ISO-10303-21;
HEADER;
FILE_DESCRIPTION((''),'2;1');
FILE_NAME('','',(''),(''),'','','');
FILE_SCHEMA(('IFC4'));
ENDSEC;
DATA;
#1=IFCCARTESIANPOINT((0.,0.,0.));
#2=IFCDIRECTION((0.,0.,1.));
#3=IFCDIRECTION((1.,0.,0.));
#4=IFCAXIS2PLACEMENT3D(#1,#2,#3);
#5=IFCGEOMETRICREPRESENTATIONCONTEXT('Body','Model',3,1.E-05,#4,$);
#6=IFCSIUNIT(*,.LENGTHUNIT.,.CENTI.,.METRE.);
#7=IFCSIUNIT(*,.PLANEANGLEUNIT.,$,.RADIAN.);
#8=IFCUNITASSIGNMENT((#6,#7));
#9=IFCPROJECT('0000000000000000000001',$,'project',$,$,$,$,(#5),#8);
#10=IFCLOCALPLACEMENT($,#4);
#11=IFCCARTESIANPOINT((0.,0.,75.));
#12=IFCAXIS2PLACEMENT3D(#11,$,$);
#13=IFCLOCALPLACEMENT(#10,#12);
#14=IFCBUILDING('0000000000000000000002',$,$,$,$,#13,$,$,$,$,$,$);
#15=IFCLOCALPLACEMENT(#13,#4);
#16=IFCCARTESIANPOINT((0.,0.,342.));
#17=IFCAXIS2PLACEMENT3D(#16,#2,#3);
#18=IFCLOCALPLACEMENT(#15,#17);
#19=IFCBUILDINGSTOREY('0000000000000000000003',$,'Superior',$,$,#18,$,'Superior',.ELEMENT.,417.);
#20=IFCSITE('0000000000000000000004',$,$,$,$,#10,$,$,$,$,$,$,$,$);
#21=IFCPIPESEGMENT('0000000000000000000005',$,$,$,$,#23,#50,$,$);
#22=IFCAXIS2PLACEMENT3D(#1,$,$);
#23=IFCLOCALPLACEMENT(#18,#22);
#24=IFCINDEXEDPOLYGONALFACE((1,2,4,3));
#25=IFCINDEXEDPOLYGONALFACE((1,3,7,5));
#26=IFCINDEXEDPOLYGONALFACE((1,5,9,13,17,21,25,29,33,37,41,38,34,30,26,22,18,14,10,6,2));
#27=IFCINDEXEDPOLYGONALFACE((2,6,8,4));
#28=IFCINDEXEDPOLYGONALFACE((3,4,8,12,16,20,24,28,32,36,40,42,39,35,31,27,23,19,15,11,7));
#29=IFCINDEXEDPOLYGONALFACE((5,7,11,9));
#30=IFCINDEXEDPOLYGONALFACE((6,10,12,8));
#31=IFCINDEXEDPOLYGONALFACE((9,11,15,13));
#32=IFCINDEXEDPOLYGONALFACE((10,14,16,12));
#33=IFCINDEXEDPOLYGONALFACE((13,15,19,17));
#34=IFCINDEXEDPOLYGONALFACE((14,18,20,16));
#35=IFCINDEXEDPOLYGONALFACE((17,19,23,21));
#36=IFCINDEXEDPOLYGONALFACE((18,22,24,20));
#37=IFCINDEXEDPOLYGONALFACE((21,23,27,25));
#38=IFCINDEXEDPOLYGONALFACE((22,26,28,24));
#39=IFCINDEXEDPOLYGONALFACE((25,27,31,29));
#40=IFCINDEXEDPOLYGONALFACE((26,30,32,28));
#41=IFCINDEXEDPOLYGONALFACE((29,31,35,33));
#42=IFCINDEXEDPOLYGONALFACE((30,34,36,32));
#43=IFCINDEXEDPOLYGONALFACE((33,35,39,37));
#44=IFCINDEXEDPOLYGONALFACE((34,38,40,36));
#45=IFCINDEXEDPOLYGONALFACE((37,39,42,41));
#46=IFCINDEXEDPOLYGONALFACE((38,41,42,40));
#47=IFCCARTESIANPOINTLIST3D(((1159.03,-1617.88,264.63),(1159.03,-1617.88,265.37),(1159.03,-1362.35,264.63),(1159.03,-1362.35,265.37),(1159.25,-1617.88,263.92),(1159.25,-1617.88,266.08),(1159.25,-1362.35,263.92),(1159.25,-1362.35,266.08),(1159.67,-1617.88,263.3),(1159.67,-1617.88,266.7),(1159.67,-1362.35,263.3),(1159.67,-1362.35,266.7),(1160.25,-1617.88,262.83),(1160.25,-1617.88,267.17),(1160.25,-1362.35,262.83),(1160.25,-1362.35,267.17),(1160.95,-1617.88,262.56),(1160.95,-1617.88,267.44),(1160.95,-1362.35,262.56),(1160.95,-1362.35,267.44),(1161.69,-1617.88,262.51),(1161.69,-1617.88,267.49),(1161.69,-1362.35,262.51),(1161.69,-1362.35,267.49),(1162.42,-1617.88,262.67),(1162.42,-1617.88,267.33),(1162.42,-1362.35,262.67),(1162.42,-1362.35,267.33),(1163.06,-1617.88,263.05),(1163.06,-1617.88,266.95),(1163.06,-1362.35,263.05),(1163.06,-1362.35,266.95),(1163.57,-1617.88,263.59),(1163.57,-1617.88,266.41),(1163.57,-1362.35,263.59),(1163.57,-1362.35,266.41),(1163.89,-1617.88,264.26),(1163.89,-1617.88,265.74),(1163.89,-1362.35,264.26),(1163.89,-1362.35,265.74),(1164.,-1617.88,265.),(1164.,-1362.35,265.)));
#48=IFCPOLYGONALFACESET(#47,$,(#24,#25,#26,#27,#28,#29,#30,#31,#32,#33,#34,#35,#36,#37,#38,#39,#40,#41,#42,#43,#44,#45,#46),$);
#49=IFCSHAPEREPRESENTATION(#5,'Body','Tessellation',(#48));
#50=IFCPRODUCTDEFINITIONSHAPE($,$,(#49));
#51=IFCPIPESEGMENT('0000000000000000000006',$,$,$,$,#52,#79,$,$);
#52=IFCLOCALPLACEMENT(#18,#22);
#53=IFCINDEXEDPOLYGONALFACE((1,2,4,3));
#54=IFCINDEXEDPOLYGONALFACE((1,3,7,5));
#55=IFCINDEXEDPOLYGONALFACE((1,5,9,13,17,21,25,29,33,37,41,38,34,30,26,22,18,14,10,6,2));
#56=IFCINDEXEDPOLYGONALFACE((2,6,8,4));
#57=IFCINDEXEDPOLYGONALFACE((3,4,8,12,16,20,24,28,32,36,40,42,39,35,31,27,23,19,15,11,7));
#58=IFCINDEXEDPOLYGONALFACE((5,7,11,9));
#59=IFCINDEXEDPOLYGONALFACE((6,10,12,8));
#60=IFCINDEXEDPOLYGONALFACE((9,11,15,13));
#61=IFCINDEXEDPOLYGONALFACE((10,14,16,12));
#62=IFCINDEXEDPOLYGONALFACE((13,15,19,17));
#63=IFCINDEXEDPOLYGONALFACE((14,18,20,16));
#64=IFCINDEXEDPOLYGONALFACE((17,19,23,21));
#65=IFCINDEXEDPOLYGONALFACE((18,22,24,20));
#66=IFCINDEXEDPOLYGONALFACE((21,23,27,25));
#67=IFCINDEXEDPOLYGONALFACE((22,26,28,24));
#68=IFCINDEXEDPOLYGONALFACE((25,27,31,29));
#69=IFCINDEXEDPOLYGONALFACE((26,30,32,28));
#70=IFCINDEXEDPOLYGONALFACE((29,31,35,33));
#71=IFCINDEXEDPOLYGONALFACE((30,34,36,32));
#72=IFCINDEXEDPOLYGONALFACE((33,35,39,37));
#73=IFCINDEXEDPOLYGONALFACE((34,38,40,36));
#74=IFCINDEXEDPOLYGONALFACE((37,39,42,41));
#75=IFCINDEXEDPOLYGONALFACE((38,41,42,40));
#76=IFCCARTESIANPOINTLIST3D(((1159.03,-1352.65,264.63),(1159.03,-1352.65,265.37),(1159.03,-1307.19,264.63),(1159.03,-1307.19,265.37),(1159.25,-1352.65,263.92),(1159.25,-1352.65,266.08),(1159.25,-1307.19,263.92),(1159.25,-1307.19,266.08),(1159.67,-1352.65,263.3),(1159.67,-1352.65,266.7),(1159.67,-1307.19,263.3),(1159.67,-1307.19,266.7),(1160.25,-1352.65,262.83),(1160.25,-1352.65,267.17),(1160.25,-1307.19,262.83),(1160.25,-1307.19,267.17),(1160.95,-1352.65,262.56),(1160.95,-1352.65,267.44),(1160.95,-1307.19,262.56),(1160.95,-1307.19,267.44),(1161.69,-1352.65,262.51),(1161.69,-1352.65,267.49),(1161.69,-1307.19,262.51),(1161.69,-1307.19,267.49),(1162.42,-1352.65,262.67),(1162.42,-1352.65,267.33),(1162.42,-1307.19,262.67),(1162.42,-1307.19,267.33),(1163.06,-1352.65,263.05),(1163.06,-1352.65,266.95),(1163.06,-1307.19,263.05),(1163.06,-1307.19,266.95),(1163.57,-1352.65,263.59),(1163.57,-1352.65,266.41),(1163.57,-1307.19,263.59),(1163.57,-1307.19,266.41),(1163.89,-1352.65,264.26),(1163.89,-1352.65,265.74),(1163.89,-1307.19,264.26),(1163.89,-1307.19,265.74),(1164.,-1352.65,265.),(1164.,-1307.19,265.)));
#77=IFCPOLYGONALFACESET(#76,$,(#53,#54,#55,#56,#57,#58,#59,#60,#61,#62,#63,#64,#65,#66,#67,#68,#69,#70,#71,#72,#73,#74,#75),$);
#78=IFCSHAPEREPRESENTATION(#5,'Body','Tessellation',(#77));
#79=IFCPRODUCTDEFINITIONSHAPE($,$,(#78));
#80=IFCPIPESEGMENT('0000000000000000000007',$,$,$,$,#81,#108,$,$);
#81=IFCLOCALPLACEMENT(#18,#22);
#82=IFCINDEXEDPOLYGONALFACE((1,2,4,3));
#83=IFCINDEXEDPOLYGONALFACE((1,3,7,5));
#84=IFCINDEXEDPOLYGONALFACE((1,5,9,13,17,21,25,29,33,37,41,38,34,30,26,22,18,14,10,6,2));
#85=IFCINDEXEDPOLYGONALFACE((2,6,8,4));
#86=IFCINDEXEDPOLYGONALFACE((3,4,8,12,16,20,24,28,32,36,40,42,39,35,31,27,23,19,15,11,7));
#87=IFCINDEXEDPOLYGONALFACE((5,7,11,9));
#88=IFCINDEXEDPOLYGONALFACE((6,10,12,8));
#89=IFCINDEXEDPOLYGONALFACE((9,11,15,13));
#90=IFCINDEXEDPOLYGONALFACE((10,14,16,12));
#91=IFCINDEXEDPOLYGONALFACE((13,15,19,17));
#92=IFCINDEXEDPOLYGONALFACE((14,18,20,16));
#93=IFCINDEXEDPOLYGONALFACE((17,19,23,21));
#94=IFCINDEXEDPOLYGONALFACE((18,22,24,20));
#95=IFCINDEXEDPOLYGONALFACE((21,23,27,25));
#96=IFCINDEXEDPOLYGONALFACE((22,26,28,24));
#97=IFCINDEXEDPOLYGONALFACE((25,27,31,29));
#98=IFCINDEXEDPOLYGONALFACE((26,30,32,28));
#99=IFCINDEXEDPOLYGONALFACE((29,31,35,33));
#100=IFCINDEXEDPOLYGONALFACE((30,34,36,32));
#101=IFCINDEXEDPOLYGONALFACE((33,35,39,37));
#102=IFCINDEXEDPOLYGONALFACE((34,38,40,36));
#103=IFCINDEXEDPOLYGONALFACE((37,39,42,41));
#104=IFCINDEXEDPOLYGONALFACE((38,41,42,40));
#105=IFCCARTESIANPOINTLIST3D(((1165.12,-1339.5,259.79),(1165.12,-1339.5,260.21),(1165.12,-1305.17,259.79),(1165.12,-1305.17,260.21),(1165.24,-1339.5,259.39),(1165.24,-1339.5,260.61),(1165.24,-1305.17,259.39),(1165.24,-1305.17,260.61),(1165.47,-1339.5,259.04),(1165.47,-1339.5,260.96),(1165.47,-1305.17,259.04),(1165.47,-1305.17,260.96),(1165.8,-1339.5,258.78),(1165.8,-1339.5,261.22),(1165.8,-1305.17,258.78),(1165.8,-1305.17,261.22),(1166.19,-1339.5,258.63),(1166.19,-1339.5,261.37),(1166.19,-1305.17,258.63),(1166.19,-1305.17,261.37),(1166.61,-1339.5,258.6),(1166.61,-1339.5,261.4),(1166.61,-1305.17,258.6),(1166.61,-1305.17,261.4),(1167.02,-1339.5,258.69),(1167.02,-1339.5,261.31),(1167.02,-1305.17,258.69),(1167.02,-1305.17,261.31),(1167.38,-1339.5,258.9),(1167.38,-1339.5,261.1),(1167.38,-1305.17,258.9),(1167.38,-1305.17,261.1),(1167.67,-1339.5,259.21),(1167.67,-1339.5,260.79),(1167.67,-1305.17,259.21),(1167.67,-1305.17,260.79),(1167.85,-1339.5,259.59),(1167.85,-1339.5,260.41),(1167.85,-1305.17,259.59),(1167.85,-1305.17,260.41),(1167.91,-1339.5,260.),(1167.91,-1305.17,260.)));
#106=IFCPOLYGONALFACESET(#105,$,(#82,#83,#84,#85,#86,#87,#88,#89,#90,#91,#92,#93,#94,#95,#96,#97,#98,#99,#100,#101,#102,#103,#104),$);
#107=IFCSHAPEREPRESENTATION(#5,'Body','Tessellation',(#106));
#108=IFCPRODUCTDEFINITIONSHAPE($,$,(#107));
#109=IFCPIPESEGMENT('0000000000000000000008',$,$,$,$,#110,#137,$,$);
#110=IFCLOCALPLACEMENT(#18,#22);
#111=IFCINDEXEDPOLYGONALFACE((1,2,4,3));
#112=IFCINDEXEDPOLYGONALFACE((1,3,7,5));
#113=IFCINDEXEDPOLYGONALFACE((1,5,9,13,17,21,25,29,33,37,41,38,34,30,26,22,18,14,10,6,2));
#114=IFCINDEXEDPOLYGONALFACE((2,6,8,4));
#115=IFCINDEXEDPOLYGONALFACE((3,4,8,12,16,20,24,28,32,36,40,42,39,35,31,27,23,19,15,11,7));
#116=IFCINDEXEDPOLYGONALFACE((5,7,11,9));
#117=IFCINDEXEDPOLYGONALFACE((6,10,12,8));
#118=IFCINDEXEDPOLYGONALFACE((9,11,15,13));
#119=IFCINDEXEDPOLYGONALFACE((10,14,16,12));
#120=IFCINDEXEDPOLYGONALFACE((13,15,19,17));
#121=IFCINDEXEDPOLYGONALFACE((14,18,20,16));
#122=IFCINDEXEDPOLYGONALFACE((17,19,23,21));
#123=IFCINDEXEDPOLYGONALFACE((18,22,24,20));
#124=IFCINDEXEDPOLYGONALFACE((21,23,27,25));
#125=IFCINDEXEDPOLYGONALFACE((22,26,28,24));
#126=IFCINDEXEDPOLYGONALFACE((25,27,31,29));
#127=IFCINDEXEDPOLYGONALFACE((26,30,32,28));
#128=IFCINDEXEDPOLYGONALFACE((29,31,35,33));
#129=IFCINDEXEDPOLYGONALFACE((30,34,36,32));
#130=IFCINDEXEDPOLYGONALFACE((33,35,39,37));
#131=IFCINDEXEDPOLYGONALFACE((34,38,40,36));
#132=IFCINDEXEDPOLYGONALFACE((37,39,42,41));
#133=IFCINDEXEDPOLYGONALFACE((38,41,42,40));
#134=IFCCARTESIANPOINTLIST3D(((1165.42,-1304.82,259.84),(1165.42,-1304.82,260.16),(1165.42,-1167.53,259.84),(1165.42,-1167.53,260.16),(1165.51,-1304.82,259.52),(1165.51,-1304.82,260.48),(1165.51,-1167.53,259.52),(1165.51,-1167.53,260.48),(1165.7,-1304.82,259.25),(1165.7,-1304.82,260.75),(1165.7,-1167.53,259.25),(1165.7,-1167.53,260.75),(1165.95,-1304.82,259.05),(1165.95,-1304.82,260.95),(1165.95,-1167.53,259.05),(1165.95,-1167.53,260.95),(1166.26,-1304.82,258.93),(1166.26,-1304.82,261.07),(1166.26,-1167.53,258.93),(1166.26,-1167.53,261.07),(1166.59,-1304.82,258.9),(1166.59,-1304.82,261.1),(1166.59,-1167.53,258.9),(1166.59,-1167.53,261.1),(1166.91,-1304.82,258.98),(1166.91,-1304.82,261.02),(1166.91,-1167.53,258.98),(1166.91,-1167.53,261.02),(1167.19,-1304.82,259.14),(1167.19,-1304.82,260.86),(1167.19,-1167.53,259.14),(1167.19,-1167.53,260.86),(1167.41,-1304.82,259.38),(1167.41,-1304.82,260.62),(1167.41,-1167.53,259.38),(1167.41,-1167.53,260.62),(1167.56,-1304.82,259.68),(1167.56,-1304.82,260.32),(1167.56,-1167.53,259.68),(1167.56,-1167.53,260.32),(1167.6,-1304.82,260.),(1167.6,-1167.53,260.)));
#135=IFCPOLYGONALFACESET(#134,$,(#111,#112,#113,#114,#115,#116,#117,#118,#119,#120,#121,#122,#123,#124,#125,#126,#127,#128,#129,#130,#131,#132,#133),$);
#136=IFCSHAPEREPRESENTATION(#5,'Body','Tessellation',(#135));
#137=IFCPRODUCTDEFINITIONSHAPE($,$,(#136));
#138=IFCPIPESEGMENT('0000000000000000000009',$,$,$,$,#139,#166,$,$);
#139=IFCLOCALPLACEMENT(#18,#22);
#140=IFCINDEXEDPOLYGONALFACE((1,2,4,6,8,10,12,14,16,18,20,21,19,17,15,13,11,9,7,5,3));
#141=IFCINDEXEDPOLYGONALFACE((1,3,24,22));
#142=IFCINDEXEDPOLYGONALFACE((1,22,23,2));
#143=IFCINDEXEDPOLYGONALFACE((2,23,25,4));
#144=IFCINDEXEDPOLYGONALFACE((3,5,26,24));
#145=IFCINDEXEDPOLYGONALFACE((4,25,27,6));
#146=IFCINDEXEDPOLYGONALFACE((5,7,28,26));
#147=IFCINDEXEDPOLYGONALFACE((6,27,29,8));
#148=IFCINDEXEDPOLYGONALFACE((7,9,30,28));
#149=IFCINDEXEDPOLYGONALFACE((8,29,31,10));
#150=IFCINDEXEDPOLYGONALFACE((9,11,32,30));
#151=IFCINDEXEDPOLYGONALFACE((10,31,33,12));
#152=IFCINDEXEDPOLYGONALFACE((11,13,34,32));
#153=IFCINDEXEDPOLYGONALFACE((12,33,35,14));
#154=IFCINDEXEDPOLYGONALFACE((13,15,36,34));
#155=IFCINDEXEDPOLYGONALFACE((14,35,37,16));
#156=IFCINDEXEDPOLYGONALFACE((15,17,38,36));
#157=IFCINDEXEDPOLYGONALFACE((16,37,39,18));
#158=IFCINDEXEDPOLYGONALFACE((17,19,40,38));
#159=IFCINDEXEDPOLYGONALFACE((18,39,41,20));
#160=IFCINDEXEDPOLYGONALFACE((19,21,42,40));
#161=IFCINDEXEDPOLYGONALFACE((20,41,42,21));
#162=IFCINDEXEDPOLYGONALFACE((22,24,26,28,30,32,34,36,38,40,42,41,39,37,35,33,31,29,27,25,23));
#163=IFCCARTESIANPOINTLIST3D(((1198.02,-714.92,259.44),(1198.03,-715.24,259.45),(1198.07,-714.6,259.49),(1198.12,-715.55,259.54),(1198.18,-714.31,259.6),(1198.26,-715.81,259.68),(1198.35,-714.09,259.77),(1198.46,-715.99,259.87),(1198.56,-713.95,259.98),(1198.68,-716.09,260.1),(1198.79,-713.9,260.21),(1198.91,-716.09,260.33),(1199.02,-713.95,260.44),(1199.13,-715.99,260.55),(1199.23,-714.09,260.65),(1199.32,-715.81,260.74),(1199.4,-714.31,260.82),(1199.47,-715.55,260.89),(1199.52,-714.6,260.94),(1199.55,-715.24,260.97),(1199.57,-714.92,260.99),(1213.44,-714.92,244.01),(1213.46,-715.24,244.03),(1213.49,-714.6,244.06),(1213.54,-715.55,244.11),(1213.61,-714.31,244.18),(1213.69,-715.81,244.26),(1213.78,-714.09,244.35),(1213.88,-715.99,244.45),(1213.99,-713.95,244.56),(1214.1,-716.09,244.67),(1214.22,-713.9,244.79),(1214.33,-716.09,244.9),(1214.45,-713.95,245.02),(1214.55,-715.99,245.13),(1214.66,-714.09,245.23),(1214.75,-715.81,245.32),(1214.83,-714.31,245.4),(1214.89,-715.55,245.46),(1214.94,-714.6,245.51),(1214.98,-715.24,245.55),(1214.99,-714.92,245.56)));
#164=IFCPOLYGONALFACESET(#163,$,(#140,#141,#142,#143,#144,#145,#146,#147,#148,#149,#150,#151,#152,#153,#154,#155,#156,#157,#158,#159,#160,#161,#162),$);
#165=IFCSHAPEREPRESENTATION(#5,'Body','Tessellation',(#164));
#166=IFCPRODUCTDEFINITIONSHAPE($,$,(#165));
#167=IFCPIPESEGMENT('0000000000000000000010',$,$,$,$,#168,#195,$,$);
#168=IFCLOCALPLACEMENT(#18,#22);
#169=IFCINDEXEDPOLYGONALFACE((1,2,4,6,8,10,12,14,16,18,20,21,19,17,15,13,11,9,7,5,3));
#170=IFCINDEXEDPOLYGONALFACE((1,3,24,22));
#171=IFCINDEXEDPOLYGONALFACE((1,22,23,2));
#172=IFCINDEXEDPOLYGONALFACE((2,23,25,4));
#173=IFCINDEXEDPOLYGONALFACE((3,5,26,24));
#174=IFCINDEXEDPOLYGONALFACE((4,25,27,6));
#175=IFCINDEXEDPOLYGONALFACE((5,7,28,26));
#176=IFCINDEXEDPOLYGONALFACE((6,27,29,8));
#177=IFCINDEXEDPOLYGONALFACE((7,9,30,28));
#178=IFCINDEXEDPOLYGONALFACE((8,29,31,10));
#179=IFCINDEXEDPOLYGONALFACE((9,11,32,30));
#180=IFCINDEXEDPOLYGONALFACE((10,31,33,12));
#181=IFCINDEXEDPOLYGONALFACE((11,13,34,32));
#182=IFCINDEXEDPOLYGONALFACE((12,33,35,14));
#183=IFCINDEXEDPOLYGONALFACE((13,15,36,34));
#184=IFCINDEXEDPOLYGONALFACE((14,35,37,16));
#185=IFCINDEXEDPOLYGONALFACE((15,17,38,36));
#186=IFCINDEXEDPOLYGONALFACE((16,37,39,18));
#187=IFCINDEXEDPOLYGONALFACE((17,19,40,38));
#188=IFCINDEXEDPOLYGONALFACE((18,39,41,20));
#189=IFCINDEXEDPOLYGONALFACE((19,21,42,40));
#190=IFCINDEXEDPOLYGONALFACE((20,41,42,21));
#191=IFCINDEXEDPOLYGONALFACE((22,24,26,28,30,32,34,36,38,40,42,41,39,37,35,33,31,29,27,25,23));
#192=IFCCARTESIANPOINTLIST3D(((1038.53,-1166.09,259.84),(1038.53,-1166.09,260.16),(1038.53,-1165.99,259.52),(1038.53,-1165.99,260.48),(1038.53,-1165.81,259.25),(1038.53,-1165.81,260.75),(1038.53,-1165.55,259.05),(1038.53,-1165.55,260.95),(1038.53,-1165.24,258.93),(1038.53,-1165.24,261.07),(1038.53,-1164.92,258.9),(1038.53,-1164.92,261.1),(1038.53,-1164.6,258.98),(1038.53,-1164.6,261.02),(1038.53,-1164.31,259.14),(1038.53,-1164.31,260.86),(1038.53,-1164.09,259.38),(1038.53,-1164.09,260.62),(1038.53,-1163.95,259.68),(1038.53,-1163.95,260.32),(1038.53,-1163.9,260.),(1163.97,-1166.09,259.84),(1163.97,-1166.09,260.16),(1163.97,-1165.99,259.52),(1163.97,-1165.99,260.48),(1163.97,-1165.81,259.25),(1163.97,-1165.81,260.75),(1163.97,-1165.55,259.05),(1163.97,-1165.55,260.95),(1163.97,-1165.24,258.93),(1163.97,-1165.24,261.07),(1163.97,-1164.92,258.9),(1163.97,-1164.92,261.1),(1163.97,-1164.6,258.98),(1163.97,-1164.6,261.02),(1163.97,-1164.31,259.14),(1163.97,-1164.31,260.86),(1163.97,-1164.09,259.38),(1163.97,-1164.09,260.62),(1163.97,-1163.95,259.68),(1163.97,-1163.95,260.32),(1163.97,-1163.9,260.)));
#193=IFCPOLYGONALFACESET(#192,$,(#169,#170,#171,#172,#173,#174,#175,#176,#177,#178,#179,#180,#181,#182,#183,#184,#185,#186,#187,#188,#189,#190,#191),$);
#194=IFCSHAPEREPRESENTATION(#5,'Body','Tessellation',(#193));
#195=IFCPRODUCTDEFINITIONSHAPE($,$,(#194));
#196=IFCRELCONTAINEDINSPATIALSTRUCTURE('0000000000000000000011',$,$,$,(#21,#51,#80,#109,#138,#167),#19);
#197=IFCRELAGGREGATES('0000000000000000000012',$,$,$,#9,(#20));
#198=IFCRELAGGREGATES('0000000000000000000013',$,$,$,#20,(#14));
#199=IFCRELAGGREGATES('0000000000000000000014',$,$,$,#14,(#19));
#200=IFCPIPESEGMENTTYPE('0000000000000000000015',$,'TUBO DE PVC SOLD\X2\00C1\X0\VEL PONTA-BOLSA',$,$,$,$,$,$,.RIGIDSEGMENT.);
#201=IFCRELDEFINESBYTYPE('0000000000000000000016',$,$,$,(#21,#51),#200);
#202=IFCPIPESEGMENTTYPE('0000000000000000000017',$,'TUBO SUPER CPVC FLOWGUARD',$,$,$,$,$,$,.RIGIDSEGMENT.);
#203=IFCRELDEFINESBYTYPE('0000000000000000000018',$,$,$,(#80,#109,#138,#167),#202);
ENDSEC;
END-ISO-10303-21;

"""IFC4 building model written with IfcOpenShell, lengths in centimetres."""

from ifc_helpers import new_model, si_unit, frame, origin_with_axes, origin_2d_with_axis, place, context, project, spatial, circle, extrude, type_object, element, save


model = new_model("IFC4")

# Units and contexts
model_context = context("Model", 3, precision=1e-05, world=origin_with_axes(), identifier="Body")
ifc_project = project(units=[si_unit("LENGTHUNIT", "METRE", prefix="CENTI"), si_unit("PLANEANGLEUNIT", "RADIAN")], contexts=[model_context])

# Site, building, storey
site_placement = place(None, origin_with_axes())
site = spatial("IfcSite", under=ifc_project, at=site_placement)
building_placement = place(site_placement, frame((0.0, 0.0, 75.0)))
building = spatial("IfcBuilding", under=site, at=building_placement)
placement = place(building_placement, origin_with_axes())
storey_placement = place(placement, frame((0.0, 0.0, 342.0), z_axis=(0.0, 0.0, 1.0), x_axis=(1.0, 0.0, 0.0)))
storey = spatial("IfcBuildingStorey", under=building, at=storey_placement, Name="Superior", LongName="Superior", CompositionType="ELEMENT", Elevation=417.0)

# Pipe segments
pipe_segment_type_1 = type_object("IfcPipeSegmentType", Name="TUBO DE PVC SOLDÁVEL PONTA-BOLSA", PredefinedType="RIGIDSEGMENT")
pipe_segment_1_placement = place(storey_placement, frame((1161.5, -1490.11, 267.5), z_axis=(0.0, 0.0, 1.0), x_axis=(1.0, 0.0, 0.0)))
element("IfcPipeSegment", 1, at=pipe_segment_1_placement, inside=storey, type_object=pipe_segment_type_1, context=model_context, shape_type="SolidModel", body=[
    extrude(circle(Radius=2.5, at=origin_2d_with_axis()), frame((0.0, 127.77, -2.5), z_axis=(0.0, -1.0, 0.0), x_axis=(1.0, 0.0, 0.0)), (0.0, 0.0, 1.0), 255.53),
])
pipe_segment_2_placement = place(storey_placement, frame((1161.5, -1329.92, 267.5), z_axis=(0.0, 0.0, 1.0), x_axis=(1.0, 0.0, 0.0)))
element("IfcPipeSegment", 2, at=pipe_segment_2_placement, inside=storey, type_object=pipe_segment_type_1, context=model_context, shape_type="SolidModel", body=[
    extrude(circle(Radius=2.5, at=origin_2d_with_axis()), frame((0.0, -22.73, -2.5), z_axis=(0.0, 1.0, 0.0), x_axis=(1.0, 0.0, 0.0)), (0.0, 0.0, 1.0), 45.46),
])
pipe_segment_type_2 = type_object("IfcPipeSegmentType", Name="TUBO SUPER CPVC FLOWGUARD", PredefinedType="RIGIDSEGMENT")
pipe_segment_3_placement = place(storey_placement, frame((1166.5, -1322.34, 261.4), z_axis=(0.0, 0.0, 1.0), x_axis=(1.0, 0.0, 0.0)))
element("IfcPipeSegment", 3, at=pipe_segment_3_placement, inside=storey, type_object=pipe_segment_type_2, context=model_context, shape_type="SolidModel", body=[
    extrude(circle(Radius=1.41, at=origin_2d_with_axis()), frame((0.0, -17.16, -1.41), z_axis=(0.0, 1.0, 0.0), x_axis=(1.0, 0.0, 0.0)), (0.0, 0.0, 1.0), 34.32),
])
pipe_segment_4_placement = place(storey_placement, frame((1166.5, -1236.18, 261.1), z_axis=(0.0, 0.0, 1.0), x_axis=(1.0, 0.0, 0.0)))
element("IfcPipeSegment", 4, at=pipe_segment_4_placement, inside=storey, type_object=pipe_segment_type_2, context=model_context, shape_type="SolidModel", body=[
    extrude(circle(Radius=1.1, at=origin_2d_with_axis()), frame((0.0, -68.65, -1.1), z_axis=(0.0, 1.0, 0.0), x_axis=(1.0, 0.0, 0.0)), (0.0, 0.0, 1.0), 137.3),
])
pipe_segment_5_placement = place(storey_placement, frame((1206.5, -715.0, 260.99), z_axis=(0.0, 0.0, 1.0), x_axis=(1.0, 0.0, 0.0)))
element("IfcPipeSegment", 5, at=pipe_segment_5_placement, inside=storey, type_object=pipe_segment_type_2, context=model_context, shape_type="SolidModel", body=[
    extrude(circle(Radius=1.1, at=origin_2d_with_axis()), frame((-7.71, 0.0, -0.78), z_axis=(0.707107, 0.0, -0.707107), x_axis=(0.0, 1.0, 0.0)), (0.0, 0.0, 1.0), 21.81),
])
pipe_segment_6_placement = place(storey_placement, frame((1101.25, -1165.0, 261.1), z_axis=(0.0, 0.0, 1.0), x_axis=(1.0, 0.0, 0.0)))
element("IfcPipeSegment", 6, at=pipe_segment_6_placement, inside=storey, type_object=pipe_segment_type_2, context=model_context, shape_type="SolidModel", body=[
    extrude(circle(Radius=1.1, at=origin_2d_with_axis()), frame((62.72, 0.0, -1.1), z_axis=(-1.0, 0.0, 0.0), x_axis=(0.0, 1.0, 0.0)), (0.0, 0.0, 1.0), 125.44),
])

save(model, "model.ifc")
